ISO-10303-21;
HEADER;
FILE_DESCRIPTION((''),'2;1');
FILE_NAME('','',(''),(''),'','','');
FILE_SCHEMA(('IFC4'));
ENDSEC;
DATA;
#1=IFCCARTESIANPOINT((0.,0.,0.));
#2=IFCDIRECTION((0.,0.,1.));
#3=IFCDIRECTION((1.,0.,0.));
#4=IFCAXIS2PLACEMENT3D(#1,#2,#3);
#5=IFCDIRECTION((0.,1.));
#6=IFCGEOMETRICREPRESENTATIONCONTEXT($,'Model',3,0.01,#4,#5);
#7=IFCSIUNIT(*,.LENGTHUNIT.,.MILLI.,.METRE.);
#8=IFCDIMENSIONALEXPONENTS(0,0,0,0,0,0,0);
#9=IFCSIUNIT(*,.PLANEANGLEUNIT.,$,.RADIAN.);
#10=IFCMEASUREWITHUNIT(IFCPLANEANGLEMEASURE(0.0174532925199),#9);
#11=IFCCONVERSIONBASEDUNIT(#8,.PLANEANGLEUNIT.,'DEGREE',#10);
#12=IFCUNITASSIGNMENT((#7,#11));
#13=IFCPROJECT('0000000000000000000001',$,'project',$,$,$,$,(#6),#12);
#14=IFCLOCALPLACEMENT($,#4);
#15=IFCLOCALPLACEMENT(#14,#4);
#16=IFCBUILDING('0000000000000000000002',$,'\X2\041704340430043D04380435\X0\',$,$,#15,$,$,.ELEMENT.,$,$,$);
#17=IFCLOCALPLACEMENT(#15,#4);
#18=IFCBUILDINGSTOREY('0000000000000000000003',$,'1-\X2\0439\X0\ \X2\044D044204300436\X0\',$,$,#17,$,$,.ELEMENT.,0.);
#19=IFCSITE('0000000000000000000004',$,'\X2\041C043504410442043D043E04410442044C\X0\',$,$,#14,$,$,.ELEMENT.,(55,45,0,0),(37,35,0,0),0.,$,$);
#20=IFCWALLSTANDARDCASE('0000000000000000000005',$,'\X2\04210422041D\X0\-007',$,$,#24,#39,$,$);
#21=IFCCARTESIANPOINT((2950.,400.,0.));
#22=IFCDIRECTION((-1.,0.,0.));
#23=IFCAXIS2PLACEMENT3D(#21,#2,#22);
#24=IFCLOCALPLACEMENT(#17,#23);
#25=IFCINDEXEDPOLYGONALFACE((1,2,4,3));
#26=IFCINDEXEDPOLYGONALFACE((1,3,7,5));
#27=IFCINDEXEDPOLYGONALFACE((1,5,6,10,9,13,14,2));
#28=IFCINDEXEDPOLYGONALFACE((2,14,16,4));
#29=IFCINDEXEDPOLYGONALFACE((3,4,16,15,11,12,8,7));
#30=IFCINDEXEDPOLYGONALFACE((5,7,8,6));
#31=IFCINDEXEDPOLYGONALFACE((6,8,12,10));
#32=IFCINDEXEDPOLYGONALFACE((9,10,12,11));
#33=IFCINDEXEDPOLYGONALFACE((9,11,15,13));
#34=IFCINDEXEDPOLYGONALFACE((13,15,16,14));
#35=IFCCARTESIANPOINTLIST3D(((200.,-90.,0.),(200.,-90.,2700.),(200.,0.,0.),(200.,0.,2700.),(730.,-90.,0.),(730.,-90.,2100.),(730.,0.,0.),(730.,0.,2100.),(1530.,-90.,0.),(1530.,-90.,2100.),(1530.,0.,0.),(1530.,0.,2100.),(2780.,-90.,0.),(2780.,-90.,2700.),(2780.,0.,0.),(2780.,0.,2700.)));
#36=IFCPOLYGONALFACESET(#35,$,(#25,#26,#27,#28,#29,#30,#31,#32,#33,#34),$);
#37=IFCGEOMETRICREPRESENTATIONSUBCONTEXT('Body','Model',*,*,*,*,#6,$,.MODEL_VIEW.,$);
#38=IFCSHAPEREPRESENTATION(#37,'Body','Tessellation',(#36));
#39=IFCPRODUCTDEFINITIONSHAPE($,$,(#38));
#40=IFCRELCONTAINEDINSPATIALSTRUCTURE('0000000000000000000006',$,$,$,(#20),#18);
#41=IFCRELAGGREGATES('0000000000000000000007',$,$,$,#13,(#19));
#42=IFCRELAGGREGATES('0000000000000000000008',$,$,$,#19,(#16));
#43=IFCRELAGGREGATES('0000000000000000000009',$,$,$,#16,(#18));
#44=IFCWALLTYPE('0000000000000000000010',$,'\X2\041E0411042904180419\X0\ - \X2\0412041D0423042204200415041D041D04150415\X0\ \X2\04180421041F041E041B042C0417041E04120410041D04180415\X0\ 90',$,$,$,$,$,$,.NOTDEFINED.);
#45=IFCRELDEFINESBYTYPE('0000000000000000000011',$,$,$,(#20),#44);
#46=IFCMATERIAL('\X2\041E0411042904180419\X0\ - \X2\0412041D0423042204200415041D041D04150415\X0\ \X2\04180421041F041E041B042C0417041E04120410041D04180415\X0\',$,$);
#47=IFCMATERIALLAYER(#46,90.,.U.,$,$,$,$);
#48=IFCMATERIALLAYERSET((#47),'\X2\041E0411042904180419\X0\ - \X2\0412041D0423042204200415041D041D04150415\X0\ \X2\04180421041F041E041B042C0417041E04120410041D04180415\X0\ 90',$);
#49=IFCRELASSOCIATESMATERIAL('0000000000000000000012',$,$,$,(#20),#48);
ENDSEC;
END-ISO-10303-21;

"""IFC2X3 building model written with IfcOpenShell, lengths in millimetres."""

from ifc_helpers import new_model, entity, si_unit, converted_unit, direction, frame, origin_with_axes, origin_2d_with_axis, place, context, subcontext, project, spatial, polyline, rectangle, outline, extrude, material, layer, layer_set, layer_usage, type_object, element, save


model = new_model("IFC2X3")

# Units and contexts
model_context = context("Model", 3, precision=0.01, world=origin_with_axes(), true_north=direction((0.0, 1.0)))
body_context = subcontext(model_context, "Body", "Model", "MODEL_VIEW")
ifc_project = project(units=[si_unit("LENGTHUNIT", "METRE", prefix="MILLI"), converted_unit("PLANEANGLEUNIT", "DEGREE", entity("IfcPlaneAngleMeasure", 0.0174532925199), si_unit("PLANEANGLEUNIT", "RADIAN"), dimensions=[0, 0, 0, 0, 0, 0, 0])], contexts=[model_context])

# Site, building, storey
site_placement = place(None, origin_with_axes())
site = spatial("IfcSite", under=ifc_project, at=site_placement, Name="Местность", CompositionType="ELEMENT", RefLatitude=(55, 45, 0, 0), RefLongitude=(37, 35, 0, 0), RefElevation=0.0)
building_placement = place(site_placement, origin_with_axes())
building = spatial("IfcBuilding", under=site, at=building_placement, Name="Здание", CompositionType="ELEMENT")
storey_placement = place(building_placement, origin_with_axes())
storey = spatial("IfcBuildingStorey", under=building, at=storey_placement, Name="1-й этаж", CompositionType="ELEMENT", Elevation=0.0)

# Shared definitions
ifc_material = material(Name="ОБЩИЙ - ВНУТРЕННЕЕ ИСПОЛЬЗОВАНИЕ")

# Shared definitions
ifc_layer_1 = layer(ifc_material, 90.0, ventilated="UNKNOWN")
ifc_layer_set_1 = layer_set([ifc_layer_1], Name="ОБЩИЙ - ВНУТРЕННЕЕ ИСПОЛЬЗОВАНИЕ 90")
wall_type_1 = type_object("IfcWallType", Name="ОБЩИЙ - ВНУТРЕННЕЕ ИСПОЛЬЗОВАНИЕ 90", PredefinedType="NOTDEFINED")

# Wall, opening
ifc_layer_usage_1 = layer_usage(ifc_layer_set_1, "AXIS2", "POSITIVE", -90.0)
wall_1_placement = place(storey_placement, frame((2950.0, 400.0, 0.0), z_axis=(0.0, 0.0, 1.0), x_axis=(-1.0, 0.0, 0.0)))
wall_1 = element("IfcWallStandardCase", 1, at=wall_1_placement, inside=storey, type_object=wall_type_1, material=ifc_layer_usage_1, Name="СТН-007", context=body_context, shape_type="SweptSolid", body=[
    extrude(outline(polyline([(200.0, -90.0), (2780.0, -90.0), (2780.0, 0.0), (200.0, 0.0), (200.0, -90.0)])), origin_with_axes(), (0.0, 0.0, 1.0), 2700.0),
])
opening_1_placement = place(wall_1_placement, frame((1130.0, 0.0, 0.0), z_axis=(0.0, 0.0, 1.0), x_axis=(1.0, 0.0, 0.0)))
element("IfcOpeningElement", 2, at=opening_1_placement, cuts=wall_1, context=body_context, shape_type="SweptSolid", body=[
    extrude(rectangle(XDim=800.0, YDim=2100.0, at=origin_2d_with_axis()), frame((0.0, 90.0, 1050.0), z_axis=(0.0, -1.0, 0.0), x_axis=(1.0, 0.0, 0.0)), (0.0, 0.0, 1.0), 270.0),
])

save(model, "model.ifc")
